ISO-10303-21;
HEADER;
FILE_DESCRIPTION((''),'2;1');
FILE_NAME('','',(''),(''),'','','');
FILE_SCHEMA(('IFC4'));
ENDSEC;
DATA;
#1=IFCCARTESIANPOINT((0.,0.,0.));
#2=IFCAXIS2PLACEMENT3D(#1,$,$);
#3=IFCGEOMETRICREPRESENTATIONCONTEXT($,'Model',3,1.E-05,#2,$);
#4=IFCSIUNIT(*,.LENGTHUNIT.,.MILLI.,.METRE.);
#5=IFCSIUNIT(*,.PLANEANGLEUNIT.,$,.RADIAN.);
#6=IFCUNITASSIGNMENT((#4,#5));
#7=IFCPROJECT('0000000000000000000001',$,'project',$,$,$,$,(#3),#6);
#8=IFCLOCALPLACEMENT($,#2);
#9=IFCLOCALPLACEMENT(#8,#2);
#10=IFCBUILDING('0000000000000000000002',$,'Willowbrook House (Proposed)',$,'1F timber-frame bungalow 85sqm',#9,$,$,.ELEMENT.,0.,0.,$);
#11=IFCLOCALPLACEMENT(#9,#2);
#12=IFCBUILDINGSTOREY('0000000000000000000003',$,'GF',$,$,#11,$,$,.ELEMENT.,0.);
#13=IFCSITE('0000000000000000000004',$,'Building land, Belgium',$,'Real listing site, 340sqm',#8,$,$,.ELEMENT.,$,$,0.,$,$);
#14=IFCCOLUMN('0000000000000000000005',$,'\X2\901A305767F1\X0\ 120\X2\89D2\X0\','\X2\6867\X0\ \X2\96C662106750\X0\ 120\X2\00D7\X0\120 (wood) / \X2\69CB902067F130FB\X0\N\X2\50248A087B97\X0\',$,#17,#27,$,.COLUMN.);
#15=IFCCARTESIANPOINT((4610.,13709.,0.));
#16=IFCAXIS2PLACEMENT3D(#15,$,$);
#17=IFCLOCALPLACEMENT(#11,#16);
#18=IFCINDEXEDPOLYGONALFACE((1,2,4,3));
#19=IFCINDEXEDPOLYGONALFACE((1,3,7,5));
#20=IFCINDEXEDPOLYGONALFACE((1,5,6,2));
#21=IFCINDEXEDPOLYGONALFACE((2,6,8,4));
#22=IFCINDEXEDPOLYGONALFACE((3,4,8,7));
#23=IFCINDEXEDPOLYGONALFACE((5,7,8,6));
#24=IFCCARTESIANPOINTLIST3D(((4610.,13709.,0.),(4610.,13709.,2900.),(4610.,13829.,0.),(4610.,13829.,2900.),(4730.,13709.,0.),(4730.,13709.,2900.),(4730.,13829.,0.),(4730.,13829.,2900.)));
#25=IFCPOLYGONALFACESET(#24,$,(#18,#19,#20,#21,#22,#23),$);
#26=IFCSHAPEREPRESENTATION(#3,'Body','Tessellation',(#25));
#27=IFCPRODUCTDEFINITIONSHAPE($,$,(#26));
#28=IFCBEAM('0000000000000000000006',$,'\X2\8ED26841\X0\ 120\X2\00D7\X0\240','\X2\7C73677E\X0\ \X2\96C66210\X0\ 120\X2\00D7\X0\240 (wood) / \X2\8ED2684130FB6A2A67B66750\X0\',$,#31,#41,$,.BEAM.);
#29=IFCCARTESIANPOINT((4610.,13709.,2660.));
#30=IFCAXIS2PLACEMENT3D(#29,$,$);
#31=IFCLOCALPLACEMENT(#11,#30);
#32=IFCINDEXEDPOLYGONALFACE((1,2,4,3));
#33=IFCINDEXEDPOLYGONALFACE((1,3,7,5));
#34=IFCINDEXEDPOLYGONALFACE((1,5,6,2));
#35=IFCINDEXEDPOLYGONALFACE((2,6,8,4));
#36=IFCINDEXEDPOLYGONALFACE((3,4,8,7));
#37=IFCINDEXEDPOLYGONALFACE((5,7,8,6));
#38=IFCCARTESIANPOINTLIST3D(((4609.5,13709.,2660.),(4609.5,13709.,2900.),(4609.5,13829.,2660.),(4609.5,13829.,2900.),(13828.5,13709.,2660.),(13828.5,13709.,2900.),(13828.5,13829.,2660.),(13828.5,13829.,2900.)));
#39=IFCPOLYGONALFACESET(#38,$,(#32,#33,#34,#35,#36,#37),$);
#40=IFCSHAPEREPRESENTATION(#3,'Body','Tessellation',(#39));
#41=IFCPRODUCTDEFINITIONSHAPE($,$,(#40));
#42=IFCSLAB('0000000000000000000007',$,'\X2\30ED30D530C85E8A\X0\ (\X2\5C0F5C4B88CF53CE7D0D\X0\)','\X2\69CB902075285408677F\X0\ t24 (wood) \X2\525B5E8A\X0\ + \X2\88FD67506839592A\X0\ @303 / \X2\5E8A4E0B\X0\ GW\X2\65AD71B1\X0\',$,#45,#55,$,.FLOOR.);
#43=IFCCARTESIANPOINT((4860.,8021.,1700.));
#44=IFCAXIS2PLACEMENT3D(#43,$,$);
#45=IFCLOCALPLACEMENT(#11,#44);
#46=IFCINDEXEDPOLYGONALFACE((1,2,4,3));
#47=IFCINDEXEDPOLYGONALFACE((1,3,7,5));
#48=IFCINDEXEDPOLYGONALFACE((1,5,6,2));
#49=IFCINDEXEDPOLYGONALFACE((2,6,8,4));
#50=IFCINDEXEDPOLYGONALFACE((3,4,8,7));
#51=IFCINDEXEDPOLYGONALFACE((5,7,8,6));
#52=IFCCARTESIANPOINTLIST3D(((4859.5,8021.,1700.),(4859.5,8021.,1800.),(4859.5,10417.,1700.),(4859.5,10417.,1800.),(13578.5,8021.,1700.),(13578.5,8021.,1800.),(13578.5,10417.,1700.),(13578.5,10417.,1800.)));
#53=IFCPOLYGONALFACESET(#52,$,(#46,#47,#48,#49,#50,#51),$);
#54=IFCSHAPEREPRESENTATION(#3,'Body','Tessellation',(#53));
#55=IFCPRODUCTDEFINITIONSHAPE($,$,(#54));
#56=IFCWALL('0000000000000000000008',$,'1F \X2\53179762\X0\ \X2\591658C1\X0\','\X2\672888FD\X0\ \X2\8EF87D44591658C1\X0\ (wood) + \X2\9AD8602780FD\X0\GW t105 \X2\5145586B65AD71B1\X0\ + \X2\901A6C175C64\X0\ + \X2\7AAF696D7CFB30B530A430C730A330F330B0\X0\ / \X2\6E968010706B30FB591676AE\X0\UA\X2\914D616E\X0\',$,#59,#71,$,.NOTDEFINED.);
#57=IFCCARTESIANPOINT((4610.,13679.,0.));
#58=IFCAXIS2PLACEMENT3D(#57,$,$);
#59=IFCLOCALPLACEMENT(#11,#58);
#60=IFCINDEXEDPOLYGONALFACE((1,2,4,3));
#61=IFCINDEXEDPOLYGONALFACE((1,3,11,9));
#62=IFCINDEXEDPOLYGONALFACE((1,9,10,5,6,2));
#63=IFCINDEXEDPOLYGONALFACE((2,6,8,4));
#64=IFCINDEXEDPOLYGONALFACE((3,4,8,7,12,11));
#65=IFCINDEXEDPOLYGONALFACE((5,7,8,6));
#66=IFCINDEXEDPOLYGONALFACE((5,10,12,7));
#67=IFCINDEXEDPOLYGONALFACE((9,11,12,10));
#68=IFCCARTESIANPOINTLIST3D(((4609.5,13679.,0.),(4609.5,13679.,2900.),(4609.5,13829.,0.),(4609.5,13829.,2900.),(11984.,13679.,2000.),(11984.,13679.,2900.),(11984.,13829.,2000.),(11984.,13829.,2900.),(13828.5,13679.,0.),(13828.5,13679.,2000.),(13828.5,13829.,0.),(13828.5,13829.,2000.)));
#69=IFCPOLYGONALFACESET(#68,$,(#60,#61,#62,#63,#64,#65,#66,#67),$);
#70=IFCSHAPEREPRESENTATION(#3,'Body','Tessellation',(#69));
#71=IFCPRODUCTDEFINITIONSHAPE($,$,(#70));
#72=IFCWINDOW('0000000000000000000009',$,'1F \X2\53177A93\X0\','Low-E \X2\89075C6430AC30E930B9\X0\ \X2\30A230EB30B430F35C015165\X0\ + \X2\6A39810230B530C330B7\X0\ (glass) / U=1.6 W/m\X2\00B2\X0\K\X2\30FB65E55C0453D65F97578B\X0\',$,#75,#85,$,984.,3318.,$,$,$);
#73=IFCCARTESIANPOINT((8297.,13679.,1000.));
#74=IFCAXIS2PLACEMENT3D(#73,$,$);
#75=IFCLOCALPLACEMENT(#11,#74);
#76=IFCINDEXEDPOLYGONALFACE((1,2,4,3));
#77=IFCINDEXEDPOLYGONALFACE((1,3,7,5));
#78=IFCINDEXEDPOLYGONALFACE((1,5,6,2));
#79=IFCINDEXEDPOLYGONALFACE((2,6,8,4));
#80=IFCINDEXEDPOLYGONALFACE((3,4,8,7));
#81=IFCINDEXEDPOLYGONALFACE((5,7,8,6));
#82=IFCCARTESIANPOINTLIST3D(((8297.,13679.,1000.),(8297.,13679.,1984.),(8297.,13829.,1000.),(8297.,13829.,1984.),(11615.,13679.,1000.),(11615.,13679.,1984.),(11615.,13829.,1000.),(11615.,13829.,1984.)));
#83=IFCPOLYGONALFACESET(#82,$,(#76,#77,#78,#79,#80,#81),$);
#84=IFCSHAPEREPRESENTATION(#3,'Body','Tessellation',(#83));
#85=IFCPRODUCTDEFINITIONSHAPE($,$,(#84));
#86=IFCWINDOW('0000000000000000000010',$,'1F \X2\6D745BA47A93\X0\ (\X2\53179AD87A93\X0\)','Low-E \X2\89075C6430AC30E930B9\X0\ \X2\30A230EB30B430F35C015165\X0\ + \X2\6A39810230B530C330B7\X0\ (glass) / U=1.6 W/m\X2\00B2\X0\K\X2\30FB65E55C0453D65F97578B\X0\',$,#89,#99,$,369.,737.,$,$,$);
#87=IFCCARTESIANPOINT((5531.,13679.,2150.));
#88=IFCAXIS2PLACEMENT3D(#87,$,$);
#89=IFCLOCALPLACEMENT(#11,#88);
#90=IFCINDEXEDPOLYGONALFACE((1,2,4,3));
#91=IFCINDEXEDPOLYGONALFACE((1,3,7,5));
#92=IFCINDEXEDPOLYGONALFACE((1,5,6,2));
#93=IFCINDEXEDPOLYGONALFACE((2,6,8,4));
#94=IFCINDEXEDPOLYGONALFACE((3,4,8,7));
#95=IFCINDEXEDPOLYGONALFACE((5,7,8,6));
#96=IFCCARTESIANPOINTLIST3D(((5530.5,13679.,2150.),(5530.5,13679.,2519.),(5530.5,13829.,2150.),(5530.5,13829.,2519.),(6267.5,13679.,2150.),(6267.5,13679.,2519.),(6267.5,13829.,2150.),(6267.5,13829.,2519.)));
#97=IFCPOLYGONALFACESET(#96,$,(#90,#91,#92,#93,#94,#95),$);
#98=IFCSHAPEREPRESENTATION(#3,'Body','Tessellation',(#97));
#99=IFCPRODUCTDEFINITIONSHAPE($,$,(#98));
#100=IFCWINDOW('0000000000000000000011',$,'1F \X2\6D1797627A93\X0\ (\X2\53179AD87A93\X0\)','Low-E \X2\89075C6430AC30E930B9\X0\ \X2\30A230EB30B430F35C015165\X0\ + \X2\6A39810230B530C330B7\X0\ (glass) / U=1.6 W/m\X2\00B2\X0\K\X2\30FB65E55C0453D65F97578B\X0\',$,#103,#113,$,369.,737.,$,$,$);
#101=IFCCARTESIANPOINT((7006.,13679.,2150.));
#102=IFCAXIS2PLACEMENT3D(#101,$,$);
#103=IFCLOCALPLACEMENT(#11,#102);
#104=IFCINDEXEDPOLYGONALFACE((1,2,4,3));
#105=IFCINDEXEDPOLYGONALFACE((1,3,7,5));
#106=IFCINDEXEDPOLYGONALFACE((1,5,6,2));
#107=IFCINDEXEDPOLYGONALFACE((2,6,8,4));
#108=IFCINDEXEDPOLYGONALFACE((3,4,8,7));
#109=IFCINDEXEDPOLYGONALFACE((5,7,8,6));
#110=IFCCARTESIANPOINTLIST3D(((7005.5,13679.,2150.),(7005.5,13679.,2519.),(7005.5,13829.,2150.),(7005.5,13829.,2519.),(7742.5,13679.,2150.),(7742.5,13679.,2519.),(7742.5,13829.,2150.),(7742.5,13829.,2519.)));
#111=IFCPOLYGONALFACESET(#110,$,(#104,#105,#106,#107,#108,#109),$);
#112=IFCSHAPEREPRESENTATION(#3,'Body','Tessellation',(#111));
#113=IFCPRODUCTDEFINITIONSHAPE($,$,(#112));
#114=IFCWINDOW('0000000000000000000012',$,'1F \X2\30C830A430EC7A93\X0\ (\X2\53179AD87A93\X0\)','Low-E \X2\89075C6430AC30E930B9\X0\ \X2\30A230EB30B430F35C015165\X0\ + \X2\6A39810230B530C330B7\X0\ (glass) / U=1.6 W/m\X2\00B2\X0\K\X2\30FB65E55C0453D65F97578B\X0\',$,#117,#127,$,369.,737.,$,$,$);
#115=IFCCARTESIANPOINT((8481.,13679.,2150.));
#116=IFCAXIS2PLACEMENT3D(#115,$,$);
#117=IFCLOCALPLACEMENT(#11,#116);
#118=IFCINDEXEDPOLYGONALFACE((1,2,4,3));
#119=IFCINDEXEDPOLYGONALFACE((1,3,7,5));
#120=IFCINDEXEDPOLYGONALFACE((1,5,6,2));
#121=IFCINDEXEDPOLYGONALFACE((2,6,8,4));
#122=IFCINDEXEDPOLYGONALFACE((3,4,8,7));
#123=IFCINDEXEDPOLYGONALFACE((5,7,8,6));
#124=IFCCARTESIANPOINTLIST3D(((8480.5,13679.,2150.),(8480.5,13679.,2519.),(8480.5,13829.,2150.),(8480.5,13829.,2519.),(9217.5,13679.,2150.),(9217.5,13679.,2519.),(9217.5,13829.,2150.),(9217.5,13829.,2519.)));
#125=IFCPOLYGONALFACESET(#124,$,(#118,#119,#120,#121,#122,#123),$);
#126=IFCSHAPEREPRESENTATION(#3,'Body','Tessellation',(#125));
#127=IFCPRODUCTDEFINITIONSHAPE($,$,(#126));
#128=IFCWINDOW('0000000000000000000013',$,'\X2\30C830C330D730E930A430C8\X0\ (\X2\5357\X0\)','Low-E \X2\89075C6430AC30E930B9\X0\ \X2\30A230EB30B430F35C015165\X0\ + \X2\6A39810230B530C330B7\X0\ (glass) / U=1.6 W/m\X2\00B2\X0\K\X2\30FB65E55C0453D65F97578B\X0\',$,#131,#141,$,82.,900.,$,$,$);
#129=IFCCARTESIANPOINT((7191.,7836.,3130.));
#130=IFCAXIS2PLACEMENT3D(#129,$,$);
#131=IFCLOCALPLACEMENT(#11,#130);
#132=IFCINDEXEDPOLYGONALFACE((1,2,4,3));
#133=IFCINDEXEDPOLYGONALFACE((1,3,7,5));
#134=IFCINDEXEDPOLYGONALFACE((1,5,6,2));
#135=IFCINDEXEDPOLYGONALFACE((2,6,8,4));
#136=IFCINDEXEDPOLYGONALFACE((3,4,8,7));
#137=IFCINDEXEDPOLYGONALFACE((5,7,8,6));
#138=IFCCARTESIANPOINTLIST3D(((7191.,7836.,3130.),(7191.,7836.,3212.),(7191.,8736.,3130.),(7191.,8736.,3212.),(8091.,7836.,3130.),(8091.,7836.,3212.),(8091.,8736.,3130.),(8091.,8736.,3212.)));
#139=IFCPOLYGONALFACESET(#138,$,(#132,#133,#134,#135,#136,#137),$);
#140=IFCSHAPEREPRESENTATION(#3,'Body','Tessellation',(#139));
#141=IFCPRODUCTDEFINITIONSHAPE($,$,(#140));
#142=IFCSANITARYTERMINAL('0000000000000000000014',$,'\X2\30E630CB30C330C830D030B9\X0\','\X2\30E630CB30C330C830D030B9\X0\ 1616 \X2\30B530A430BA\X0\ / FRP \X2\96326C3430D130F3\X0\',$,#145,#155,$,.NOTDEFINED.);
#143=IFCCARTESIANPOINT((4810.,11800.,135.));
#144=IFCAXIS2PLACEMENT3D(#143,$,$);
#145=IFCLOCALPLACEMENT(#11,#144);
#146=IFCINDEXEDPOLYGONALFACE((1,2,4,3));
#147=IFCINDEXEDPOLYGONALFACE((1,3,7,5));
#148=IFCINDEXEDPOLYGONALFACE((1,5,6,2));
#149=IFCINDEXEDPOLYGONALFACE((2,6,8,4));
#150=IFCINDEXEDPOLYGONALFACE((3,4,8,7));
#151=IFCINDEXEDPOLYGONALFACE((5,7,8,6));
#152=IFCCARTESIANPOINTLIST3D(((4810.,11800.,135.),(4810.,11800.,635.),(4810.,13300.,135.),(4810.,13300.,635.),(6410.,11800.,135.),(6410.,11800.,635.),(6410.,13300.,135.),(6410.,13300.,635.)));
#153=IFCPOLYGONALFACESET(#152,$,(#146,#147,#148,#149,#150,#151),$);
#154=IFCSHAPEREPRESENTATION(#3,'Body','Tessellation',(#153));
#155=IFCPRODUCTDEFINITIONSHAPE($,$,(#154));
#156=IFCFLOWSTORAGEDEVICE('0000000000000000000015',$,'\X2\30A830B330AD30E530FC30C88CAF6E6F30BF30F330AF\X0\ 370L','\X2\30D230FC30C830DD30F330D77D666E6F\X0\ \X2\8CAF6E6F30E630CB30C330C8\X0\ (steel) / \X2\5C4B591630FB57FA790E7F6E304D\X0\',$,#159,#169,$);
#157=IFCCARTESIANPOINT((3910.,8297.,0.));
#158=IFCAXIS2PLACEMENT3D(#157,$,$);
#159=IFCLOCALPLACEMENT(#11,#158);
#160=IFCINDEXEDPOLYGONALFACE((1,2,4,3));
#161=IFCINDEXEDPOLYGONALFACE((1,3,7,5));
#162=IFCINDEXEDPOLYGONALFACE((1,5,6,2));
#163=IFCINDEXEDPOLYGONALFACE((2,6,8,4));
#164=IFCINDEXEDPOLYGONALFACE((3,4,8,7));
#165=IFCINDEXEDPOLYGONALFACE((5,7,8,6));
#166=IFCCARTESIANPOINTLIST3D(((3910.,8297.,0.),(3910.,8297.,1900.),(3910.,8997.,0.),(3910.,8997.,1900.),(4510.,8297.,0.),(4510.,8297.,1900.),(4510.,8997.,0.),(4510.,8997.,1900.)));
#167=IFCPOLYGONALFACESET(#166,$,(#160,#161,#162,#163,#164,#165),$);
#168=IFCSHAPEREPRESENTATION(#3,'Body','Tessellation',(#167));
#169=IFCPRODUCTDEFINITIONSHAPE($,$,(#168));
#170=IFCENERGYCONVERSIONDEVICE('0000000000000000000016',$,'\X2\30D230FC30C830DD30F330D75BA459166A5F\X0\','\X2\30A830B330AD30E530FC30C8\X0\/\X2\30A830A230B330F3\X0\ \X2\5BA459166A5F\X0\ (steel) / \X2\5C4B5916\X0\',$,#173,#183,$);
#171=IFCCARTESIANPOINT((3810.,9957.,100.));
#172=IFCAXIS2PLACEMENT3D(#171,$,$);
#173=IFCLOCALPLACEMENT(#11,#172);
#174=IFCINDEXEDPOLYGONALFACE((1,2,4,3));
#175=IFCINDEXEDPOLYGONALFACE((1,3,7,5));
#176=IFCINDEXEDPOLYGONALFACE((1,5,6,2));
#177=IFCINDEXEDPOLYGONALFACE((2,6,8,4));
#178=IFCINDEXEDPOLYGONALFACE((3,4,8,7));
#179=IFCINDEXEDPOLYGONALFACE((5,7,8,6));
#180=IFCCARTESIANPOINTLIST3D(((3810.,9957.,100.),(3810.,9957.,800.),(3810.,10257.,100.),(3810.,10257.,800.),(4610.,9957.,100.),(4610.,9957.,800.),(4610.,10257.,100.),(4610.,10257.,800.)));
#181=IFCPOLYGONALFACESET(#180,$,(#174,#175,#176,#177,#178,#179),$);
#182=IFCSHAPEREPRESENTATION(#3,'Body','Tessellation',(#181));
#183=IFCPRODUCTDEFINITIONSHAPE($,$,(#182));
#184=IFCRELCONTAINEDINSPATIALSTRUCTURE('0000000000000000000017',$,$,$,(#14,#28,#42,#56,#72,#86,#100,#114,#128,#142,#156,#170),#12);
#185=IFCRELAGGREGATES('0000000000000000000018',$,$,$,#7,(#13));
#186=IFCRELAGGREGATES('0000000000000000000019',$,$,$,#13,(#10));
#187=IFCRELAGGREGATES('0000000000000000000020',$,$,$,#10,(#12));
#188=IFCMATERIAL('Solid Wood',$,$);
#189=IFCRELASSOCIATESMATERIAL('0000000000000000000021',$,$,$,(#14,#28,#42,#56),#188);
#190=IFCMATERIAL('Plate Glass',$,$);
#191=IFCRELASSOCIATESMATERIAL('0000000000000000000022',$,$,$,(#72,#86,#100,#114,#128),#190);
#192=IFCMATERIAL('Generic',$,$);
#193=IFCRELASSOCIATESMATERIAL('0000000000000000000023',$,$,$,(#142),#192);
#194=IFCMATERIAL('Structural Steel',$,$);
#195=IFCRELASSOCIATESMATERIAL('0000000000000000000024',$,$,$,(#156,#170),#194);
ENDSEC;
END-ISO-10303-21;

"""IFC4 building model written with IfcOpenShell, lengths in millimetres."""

from ifc_helpers import new_model, si_unit, frame, frame_2d, origin, place, context, project, spatial, rectangle, extrude, material, element, fill, save


model = new_model("IFC4")

# Units and contexts
model_context = context("Model", 3, precision=1e-05, world=origin())
ifc_project = project(units=[si_unit("LENGTHUNIT", "METRE", prefix="MILLI"), si_unit("PLANEANGLEUNIT", "RADIAN")], contexts=[model_context])

# Site, building, storey
site_placement = place(None, origin())
site = spatial("IfcSite", under=ifc_project, at=site_placement, Name="Building land, Belgium", ObjectType="Real listing site, 340sqm", CompositionType="ELEMENT", RefElevation=0.0)
building_placement = place(site_placement, origin())
building = spatial("IfcBuilding", under=site, at=building_placement, Name="Willowbrook House (Proposed)", ObjectType="1F timber-frame bungalow 85sqm", CompositionType="ELEMENT", ElevationOfRefHeight=0.0, ElevationOfTerrain=0.0)
storey_placement = place(building_placement, origin())
storey = spatial("IfcBuildingStorey", under=building, at=storey_placement, Name="GF", CompositionType="ELEMENT", Elevation=0.0)

# Column
ifc_material_1 = material(Name="Solid Wood")
column_1_placement = place(storey_placement, frame((4610.0, 13709.0, 0.0)))
element("IfcColumn", 1, at=column_1_placement, inside=storey, material=ifc_material_1, Name="通し柱 120角", Description="桧 集成材 120×120 (wood) / 構造柱・N値計算", PredefinedType="COLUMN", context=model_context, shape_type="SweptSolid", body=[
    extrude(rectangle(XDim=120.0, YDim=120.0, at=frame_2d((60.0, 60.0))), frame((4610.0, 13709.0, 0.0)), (0.0, 0.0, 1.0), 2900.0),
])

# Beam
beam_1_placement = place(storey_placement, frame((4610.0, 13709.0, 2660.0)))
element("IfcBeam", 2, at=beam_1_placement, inside=storey, material=ifc_material_1, Name="軒桁 120×240", Description="米松 集成 120×240 (wood) / 軒桁・横架材", PredefinedType="BEAM", context=model_context, shape_type="SweptSolid", body=[
    extrude(rectangle(XDim=9219.0, YDim=120.0, at=frame_2d((4609.0, 60.0))), frame((4610.0, 13709.0, 2660.0)), (0.0, 0.0, 1.0), 240.0),
])

# Slab
slab_placement = place(storey_placement, frame((4860.0, 8021.0, 1700.0)))
element("IfcSlab", 3, at=slab_placement, inside=storey, material=ifc_material_1, Name="ロフト床 (小屋裏収納)", Description="構造用合板 t24 (wood) 剛床 + 製材根太 @303 / 床下 GW断熱", PredefinedType="FLOOR", context=model_context, shape_type="SweptSolid", body=[
    extrude(rectangle(XDim=8719.0, YDim=2396.0, at=frame_2d((4359.0, 1198.0))), frame((4860.0, 8021.0, 1700.0)), (0.0, 0.0, 1.0), 100.0),
])

# Wall, openings, windows
wall_1_placement = place(storey_placement, frame((4610.0, 13679.0, 0.0)))
wall_1 = element("IfcWall", 4, at=wall_1_placement, inside=storey, material=ifc_material_1, Name="1F 北面 外壁", Description="木製 軸組外壁 (wood) + 高性能GW t105 充填断熱 + 通気層 + 窯業系サイディング / 準耐火・外皮UA配慮", PredefinedType="NOTDEFINED", context=model_context, shape_type="SweptSolid", body=[
    extrude(rectangle(XDim=9219.0, YDim=150.0, at=frame_2d((4609.0, 75.0))), frame((4610.0, 13679.0, 0.0)), (0.0, 0.0, 1.0), 2900.0),
])
opening_1_placement = place(storey_placement, frame((8297.0, 13679.0, 1000.0)))
opening_1 = element("IfcOpeningElement", 5, at=opening_1_placement, cuts=wall_1, PredefinedType="NOTDEFINED", context=model_context, shape_type="SweptSolid", body=[
    extrude(rectangle(XDim=3318.0, YDim=150.0, at=frame_2d((1659.0, 75.0))), frame((8297.0, 13679.0, 1000.0)), (0.0, 0.0, 1.0), 984.0),
])
opening_2_placement = place(storey_placement, frame((5531.0, 13679.0, 2150.0)))
opening_2 = element("IfcOpeningElement", 6, at=opening_2_placement, cuts=wall_1, PredefinedType="NOTDEFINED", context=model_context, shape_type="SweptSolid", body=[
    extrude(rectangle(XDim=737.0, YDim=150.0, at=frame_2d((368.0, 75.0))), frame((5531.0, 13679.0, 2150.0)), (0.0, 0.0, 1.0), 369.0),
])
opening_3_placement = place(storey_placement, frame((7006.0, 13679.0, 2150.0)))
opening_3 = element("IfcOpeningElement", 7, at=opening_3_placement, cuts=wall_1, PredefinedType="NOTDEFINED", context=model_context, shape_type="SweptSolid", body=[
    extrude(rectangle(XDim=737.0, YDim=150.0, at=frame_2d((368.0, 75.0))), frame((7006.0, 13679.0, 2150.0)), (0.0, 0.0, 1.0), 369.0),
])
opening_4_placement = place(storey_placement, frame((8481.0, 13679.0, 2150.0)))
opening_4 = element("IfcOpeningElement", 8, at=opening_4_placement, cuts=wall_1, PredefinedType="NOTDEFINED", context=model_context, shape_type="SweptSolid", body=[
    extrude(rectangle(XDim=737.0, YDim=150.0, at=frame_2d((368.0, 75.0))), frame((8481.0, 13679.0, 2150.0)), (0.0, 0.0, 1.0), 369.0),
])
ifc_material_2 = material(Name="Plate Glass")
window_1_placement = place(storey_placement, frame((8297.0, 13679.0, 1000.0)))
window_1 = element("IfcWindow", 9, at=window_1_placement, inside=storey, material=ifc_material_2, Name="1F 北窓", Description="Low-E 複層ガラス アルゴン封入 + 樹脂サッシ (glass) / U=1.6 W/m²K・日射取得型", OverallHeight=984.0, OverallWidth=3318.0, context=model_context, shape_type="SweptSolid", body=[
    extrude(rectangle(XDim=3318.0, YDim=150.0, at=frame_2d((1659.0, 75.0))), frame((8297.0, 13679.0, 1000.0)), (0.0, 0.0, 1.0), 984.0),
])
fill(opening_1, window_1)
window_2_placement = place(storey_placement, frame((5531.0, 13679.0, 2150.0)))
window_2 = element("IfcWindow", 10, at=window_2_placement, inside=storey, material=ifc_material_2, Name="1F 浴室窓 (北高窓)", Description="Low-E 複層ガラス アルゴン封入 + 樹脂サッシ (glass) / U=1.6 W/m²K・日射取得型", OverallHeight=369.0, OverallWidth=737.0, context=model_context, shape_type="SweptSolid", body=[
    extrude(rectangle(XDim=737.0, YDim=150.0, at=frame_2d((368.0, 75.0))), frame((5531.0, 13679.0, 2150.0)), (0.0, 0.0, 1.0), 369.0),
])
fill(opening_2, window_2)
window_3_placement = place(storey_placement, frame((7006.0, 13679.0, 2150.0)))
window_3 = element("IfcWindow", 11, at=window_3_placement, inside=storey, material=ifc_material_2, Name="1F 洗面窓 (北高窓)", Description="Low-E 複層ガラス アルゴン封入 + 樹脂サッシ (glass) / U=1.6 W/m²K・日射取得型", OverallHeight=369.0, OverallWidth=737.0, context=model_context, shape_type="SweptSolid", body=[
    extrude(rectangle(XDim=737.0, YDim=150.0, at=frame_2d((368.0, 75.0))), frame((7006.0, 13679.0, 2150.0)), (0.0, 0.0, 1.0), 369.0),
])
fill(opening_3, window_3)
window_4_placement = place(storey_placement, frame((8481.0, 13679.0, 2150.0)))
window_4 = element("IfcWindow", 12, at=window_4_placement, inside=storey, material=ifc_material_2, Name="1F トイレ窓 (北高窓)", Description="Low-E 複層ガラス アルゴン封入 + 樹脂サッシ (glass) / U=1.6 W/m²K・日射取得型", OverallHeight=369.0, OverallWidth=737.0, context=model_context, shape_type="SweptSolid", body=[
    extrude(rectangle(XDim=737.0, YDim=150.0, at=frame_2d((368.0, 75.0))), frame((8481.0, 13679.0, 2150.0)), (0.0, 0.0, 1.0), 369.0),
])
fill(opening_4, window_4)

# Window
window_5_placement = place(storey_placement, frame((7191.0, 7836.0, 3130.0)))
element("IfcWindow", 13, at=window_5_placement, inside=storey, material=ifc_material_2, Name="トップライト (南)", Description="Low-E 複層ガラス アルゴン封入 + 樹脂サッシ (glass) / U=1.6 W/m²K・日射取得型", OverallHeight=82.0, OverallWidth=900.0, context=model_context, shape_type="SweptSolid", body=[
    extrude(rectangle(XDim=900.0, YDim=900.0, at=frame_2d((450.0, 450.0))), frame((7191.0, 7836.0, 3130.0)), (0.0, 0.0, 1.0), 82.0),
])

# Sanitary terminal
ifc_material_3 = material(Name="Generic")
sanitary_terminal_placement = place(storey_placement, frame((4810.0, 11800.0, 135.0)))
element("IfcSanitaryTerminal", 14, at=sanitary_terminal_placement, inside=storey, material=ifc_material_3, Name="ユニットバス", Description="ユニットバス 1616 サイズ / FRP 防水パン", PredefinedType="NOTDEFINED", context=model_context, shape_type="SweptSolid", body=[
    extrude(rectangle(XDim=1600.0, YDim=1500.0, at=frame_2d((800.0, 750.0))), frame((4810.0, 11800.0, 135.0)), (0.0, 0.0, 1.0), 500.0),
])

# Flow storage device
ifc_material_4 = material(Name="Structural Steel")
flow_storage_device_placement = place(storey_placement, frame((3910.0, 8297.0, 0.0)))
element("IfcFlowStorageDevice", 15, at=flow_storage_device_placement, inside=storey, material=ifc_material_4, Name="エコキュート貯湯タンク 370L", Description="ヒートポンプ給湯 貯湯ユニット (steel) / 屋外・基礎置き", context=model_context, shape_type="SweptSolid", body=[
    extrude(rectangle(XDim=600.0, YDim=700.0, at=frame_2d((300.0, 350.0))), frame((3910.0, 8297.0, 0.0)), (0.0, 0.0, 1.0), 1900.0),
])

# Energy conversion device
energy_conversion_device_placement = place(storey_placement, frame((3810.0, 9957.0, 100.0)))
element("IfcEnergyConversionDevice", 16, at=energy_conversion_device_placement, inside=storey, material=ifc_material_4, Name="ヒートポンプ室外機", Description="エコキュート/エアコン 室外機 (steel) / 屋外", context=model_context, shape_type="SweptSolid", body=[
    extrude(rectangle(XDim=800.0, YDim=300.0, at=frame_2d((400.0, 150.0))), frame((3810.0, 9957.0, 100.0)), (0.0, 0.0, 1.0), 700.0),
])

save(model, "model.ifc")
